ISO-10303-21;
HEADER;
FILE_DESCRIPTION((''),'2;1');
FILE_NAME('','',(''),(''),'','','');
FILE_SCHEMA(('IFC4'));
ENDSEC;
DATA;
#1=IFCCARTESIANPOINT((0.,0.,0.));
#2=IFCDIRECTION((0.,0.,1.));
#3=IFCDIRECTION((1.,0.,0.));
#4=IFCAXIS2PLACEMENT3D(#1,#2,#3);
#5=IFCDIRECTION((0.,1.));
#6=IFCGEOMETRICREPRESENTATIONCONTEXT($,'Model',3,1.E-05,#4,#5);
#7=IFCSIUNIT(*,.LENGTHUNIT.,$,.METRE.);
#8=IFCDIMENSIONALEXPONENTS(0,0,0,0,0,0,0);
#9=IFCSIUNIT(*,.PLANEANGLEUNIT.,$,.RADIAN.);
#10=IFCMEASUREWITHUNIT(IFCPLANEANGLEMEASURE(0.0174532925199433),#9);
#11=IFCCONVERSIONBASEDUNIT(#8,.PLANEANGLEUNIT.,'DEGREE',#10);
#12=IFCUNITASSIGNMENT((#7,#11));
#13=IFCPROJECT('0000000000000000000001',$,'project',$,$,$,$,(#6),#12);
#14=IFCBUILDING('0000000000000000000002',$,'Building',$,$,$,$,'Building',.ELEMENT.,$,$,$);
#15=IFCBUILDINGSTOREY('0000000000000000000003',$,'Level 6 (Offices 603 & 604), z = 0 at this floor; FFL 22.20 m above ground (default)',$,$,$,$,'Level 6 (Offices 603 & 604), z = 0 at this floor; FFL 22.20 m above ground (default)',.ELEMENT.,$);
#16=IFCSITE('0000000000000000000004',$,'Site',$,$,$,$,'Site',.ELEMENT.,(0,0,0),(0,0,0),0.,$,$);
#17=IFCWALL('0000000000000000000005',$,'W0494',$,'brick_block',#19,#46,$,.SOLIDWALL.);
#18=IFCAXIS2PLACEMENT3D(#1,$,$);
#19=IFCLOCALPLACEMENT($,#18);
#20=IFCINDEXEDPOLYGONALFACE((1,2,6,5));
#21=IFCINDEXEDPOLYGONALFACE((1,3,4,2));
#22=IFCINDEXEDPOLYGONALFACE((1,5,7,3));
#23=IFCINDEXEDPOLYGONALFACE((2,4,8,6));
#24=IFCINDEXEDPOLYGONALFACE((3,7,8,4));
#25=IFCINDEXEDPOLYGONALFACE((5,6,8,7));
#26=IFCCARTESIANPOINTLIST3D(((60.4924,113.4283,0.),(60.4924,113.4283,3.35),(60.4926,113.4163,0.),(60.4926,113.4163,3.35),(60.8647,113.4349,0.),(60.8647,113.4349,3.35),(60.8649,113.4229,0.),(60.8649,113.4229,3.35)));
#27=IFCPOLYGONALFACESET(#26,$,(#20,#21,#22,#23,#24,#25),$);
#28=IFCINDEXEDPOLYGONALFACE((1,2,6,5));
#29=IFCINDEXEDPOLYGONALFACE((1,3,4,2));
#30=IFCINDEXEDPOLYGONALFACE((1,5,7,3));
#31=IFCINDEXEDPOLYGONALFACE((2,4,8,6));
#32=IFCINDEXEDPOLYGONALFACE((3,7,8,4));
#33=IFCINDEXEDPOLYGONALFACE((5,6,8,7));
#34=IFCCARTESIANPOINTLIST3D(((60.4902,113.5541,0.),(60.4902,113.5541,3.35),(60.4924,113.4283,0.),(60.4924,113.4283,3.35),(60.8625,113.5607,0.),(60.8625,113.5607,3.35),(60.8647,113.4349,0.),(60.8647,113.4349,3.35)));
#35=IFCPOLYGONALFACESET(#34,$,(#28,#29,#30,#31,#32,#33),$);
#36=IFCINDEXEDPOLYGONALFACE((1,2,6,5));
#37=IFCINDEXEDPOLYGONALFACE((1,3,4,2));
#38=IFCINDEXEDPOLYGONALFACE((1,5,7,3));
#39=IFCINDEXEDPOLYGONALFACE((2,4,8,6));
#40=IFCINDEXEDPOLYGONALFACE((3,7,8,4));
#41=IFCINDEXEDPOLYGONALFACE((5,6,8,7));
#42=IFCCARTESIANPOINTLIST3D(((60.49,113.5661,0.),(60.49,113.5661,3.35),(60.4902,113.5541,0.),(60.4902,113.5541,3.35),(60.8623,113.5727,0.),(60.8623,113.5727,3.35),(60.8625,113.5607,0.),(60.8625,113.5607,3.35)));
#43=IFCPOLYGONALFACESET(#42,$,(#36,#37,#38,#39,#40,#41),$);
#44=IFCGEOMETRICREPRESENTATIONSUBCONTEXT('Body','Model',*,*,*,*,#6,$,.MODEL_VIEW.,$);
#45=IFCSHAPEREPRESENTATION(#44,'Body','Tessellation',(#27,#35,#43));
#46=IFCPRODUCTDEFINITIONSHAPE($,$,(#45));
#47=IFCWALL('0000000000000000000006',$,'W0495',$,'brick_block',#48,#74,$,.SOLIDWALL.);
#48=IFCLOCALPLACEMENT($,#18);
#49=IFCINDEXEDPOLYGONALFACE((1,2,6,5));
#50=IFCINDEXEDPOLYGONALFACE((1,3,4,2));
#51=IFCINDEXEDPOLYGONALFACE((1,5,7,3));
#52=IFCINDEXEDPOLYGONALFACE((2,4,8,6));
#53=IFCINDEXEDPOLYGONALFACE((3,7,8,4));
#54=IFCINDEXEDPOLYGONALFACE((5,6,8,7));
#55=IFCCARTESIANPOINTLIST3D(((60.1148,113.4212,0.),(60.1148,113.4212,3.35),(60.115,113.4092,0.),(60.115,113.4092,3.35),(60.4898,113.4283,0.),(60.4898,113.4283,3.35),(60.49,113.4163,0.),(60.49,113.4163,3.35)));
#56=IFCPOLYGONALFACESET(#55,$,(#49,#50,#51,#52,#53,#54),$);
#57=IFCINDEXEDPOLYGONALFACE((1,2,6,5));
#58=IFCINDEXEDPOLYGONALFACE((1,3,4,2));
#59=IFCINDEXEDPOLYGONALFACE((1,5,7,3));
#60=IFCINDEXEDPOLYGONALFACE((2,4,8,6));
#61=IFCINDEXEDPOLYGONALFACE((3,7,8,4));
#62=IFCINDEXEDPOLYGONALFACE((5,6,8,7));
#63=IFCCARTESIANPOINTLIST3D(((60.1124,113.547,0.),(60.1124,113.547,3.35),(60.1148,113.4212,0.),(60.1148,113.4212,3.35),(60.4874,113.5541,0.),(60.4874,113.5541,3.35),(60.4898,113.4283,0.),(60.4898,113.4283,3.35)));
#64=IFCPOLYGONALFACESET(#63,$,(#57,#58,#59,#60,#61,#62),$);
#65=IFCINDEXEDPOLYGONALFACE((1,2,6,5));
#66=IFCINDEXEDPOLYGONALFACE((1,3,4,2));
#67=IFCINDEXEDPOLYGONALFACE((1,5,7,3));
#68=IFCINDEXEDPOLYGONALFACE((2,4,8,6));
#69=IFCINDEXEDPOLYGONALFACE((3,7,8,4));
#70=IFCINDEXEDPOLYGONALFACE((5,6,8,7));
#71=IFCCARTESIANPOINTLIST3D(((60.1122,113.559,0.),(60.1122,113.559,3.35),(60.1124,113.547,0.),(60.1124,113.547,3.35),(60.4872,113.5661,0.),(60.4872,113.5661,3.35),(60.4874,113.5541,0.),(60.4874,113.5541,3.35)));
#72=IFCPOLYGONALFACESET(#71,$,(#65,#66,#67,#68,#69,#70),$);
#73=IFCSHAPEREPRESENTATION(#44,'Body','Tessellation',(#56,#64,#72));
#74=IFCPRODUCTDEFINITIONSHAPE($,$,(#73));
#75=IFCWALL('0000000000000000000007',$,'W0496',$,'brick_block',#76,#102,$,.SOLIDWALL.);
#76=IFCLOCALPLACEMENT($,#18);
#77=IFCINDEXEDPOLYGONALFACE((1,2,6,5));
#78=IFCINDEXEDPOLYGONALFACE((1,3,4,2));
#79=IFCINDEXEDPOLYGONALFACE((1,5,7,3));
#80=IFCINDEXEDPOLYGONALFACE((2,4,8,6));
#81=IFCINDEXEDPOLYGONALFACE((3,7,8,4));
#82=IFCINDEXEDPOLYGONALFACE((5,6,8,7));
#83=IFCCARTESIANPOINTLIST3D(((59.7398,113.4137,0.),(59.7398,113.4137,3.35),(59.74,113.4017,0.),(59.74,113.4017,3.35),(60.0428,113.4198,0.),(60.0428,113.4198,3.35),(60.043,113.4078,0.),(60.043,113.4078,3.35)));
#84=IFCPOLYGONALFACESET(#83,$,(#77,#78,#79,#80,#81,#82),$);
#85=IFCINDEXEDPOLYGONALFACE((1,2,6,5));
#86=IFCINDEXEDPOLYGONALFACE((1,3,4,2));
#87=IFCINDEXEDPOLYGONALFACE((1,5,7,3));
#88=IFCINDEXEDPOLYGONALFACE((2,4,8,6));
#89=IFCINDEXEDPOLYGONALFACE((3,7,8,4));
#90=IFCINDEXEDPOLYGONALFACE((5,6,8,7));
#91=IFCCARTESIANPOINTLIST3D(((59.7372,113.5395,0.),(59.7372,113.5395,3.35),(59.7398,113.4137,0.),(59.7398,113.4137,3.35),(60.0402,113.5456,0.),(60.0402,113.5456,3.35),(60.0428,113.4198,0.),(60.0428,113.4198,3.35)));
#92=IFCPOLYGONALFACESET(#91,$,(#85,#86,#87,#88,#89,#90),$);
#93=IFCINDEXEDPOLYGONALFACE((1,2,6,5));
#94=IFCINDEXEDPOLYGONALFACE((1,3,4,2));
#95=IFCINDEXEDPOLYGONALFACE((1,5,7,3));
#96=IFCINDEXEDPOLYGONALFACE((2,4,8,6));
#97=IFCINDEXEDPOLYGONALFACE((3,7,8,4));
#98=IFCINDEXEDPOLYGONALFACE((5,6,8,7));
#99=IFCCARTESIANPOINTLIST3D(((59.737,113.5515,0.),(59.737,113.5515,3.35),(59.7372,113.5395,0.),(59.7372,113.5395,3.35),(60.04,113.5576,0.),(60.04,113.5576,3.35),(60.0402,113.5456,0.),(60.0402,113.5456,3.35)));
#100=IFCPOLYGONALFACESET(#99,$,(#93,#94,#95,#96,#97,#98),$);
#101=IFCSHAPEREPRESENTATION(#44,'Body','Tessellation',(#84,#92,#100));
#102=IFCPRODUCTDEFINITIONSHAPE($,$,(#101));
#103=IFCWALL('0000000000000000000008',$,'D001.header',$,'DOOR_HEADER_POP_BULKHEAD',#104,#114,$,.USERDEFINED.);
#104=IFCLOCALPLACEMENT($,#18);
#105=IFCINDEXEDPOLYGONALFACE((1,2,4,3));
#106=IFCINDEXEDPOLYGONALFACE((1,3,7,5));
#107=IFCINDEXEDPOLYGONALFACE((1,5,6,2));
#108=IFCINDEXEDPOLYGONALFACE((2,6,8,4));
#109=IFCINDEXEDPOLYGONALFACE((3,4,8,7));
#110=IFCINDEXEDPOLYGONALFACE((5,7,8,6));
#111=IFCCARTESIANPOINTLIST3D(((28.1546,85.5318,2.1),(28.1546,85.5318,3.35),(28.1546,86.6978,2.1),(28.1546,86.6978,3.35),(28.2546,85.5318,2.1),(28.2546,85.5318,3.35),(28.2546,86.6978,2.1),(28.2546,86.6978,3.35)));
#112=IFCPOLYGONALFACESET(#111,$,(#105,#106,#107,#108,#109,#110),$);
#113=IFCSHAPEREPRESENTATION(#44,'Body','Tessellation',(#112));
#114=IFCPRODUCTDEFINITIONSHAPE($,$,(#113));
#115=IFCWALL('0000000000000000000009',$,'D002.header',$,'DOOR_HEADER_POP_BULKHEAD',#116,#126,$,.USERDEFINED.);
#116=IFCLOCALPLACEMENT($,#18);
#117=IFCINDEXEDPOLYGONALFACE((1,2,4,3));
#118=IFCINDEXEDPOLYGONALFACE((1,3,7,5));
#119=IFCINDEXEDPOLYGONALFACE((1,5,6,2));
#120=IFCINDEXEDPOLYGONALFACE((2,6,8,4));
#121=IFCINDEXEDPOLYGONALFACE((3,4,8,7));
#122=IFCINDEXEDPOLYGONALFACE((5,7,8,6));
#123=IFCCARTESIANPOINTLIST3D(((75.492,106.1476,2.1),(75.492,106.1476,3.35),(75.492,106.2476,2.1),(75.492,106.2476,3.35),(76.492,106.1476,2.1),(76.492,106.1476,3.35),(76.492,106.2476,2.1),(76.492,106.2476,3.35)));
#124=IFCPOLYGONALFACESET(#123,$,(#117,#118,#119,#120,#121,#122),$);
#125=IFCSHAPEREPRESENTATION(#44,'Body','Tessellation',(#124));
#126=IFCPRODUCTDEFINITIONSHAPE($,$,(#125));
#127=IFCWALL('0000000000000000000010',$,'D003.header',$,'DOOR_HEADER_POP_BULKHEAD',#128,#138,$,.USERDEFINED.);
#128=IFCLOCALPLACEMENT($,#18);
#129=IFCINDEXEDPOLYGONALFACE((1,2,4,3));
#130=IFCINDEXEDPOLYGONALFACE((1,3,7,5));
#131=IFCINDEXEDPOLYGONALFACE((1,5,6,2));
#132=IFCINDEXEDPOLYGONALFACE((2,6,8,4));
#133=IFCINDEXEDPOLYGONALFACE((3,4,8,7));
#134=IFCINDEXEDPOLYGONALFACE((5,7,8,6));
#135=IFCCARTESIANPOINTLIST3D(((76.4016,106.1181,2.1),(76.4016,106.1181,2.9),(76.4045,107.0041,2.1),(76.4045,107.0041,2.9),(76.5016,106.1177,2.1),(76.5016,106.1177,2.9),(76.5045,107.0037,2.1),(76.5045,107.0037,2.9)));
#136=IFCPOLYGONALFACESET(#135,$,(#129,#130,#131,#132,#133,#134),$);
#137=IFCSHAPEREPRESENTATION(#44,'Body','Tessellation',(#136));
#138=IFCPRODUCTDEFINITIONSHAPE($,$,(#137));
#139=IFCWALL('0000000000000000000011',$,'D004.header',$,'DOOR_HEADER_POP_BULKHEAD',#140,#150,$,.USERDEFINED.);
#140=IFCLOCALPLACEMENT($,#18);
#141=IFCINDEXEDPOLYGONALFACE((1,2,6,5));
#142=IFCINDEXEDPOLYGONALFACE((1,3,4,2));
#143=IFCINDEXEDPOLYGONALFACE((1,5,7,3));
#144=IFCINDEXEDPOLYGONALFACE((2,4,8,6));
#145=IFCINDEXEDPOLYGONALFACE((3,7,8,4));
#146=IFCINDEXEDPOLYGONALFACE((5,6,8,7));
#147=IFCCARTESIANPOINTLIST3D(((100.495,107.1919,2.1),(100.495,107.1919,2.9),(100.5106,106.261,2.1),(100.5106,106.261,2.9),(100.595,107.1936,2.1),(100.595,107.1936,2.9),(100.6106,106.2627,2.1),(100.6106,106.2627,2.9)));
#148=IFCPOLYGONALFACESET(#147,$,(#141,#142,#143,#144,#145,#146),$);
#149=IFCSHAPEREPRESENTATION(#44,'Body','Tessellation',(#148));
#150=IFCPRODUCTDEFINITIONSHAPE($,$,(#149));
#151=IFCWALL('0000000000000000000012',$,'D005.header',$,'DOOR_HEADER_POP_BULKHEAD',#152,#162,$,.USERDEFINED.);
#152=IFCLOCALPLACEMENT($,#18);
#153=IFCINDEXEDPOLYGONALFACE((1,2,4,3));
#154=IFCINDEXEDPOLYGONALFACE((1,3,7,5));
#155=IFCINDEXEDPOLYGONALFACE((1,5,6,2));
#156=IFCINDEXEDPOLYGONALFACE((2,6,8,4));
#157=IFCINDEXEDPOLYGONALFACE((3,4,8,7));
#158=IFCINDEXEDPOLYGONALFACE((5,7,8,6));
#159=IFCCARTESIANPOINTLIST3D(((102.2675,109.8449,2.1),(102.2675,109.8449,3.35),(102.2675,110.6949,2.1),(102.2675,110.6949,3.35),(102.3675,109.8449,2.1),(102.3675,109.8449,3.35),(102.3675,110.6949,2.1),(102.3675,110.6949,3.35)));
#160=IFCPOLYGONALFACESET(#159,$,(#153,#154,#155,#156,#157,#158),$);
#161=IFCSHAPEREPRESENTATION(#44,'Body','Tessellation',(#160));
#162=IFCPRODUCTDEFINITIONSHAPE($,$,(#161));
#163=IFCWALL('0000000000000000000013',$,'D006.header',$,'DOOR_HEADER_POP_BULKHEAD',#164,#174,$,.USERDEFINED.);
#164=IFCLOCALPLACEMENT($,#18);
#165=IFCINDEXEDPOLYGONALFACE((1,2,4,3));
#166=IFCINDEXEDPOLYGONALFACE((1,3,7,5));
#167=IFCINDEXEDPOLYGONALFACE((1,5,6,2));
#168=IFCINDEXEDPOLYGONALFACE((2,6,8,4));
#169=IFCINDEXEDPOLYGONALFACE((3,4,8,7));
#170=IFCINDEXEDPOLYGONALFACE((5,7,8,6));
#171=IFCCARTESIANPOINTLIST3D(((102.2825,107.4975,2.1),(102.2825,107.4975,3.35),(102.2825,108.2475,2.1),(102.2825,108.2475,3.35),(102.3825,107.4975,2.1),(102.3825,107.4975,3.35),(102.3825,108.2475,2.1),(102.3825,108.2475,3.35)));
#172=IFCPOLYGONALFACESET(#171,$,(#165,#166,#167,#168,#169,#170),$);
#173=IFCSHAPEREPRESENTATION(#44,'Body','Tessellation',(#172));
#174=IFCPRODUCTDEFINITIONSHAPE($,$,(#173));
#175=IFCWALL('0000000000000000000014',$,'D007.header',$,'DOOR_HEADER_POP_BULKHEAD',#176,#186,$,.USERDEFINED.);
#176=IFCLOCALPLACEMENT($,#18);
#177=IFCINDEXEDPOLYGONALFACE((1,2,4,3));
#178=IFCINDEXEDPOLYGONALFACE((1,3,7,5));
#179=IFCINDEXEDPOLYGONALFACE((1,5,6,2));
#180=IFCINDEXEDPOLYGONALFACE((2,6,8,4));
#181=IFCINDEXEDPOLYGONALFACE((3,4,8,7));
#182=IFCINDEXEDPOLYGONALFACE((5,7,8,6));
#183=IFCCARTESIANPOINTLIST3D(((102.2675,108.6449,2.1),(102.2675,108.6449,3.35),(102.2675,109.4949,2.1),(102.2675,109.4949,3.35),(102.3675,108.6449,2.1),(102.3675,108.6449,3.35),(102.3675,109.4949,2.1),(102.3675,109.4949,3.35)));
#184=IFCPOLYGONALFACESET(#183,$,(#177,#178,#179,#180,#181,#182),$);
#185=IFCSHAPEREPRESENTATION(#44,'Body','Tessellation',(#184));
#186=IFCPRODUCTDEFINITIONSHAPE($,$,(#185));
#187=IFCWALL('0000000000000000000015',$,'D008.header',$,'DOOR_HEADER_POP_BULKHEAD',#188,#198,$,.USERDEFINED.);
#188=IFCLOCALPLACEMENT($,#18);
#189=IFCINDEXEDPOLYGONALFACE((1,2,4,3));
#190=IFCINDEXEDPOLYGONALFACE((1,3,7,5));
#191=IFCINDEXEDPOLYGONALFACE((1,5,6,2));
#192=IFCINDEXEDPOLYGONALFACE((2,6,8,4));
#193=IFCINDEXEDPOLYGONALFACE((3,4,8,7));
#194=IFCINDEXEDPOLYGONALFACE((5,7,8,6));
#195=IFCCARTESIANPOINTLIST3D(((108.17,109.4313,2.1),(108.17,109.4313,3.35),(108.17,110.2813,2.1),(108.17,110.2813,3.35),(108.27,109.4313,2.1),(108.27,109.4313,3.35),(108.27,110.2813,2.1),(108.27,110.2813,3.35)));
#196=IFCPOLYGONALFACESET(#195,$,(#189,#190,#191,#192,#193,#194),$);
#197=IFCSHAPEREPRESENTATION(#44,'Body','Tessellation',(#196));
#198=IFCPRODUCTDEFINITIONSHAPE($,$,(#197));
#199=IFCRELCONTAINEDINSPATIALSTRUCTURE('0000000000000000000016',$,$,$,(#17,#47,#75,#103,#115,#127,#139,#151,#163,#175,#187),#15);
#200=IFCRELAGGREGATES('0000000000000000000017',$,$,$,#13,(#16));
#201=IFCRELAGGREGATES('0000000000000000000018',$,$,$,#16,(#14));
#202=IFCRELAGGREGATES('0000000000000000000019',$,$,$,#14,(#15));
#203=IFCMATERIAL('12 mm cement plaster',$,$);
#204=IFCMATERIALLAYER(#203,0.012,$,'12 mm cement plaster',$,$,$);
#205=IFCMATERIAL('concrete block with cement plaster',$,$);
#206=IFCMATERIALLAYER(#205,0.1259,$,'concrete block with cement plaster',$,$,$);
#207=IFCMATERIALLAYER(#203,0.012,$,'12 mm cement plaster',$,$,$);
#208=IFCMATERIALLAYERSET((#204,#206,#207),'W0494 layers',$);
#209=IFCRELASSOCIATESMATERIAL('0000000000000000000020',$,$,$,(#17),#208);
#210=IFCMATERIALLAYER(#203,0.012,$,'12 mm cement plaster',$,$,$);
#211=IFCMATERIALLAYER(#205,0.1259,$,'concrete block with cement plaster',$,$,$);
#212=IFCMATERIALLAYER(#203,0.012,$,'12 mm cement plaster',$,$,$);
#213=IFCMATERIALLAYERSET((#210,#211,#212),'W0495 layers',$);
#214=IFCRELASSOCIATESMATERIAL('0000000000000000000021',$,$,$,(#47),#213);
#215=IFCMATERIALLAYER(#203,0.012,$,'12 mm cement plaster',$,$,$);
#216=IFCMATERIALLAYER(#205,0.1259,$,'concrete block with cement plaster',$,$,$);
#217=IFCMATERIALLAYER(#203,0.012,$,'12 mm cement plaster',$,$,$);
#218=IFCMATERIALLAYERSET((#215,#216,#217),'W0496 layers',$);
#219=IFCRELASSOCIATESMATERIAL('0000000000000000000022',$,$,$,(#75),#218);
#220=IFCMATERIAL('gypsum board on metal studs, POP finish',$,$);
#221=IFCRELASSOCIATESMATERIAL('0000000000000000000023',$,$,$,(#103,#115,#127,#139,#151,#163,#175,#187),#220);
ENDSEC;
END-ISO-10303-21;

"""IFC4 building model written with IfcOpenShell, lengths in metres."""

from ifc_helpers import new_model, entity, si_unit, converted_unit, direction, frame, frame_2d, origin_with_axes, origin_2d_with_axis, place, context, subcontext, project, spatial, rectangle, extrude, material, layer, layer_set, layer_usage, element, save


model = new_model("IFC4")

# Units and contexts
model_context = context("Model", 3, precision=1e-05, world=origin_with_axes(), true_north=direction((0.0, 1.0)))
body_context = subcontext(model_context, "Body", "Model", "MODEL_VIEW")
ifc_project = project(units=[si_unit("LENGTHUNIT", "METRE"), converted_unit("PLANEANGLEUNIT", "DEGREE", entity("IfcPlaneAngleMeasure", 0.0174532925199433), si_unit("PLANEANGLEUNIT", "RADIAN"), dimensions=[0, 0, 0, 0, 0, 0, 0])], contexts=[model_context])

# Site, building, storey
site = spatial("IfcSite", under=ifc_project, Name="Site", LongName="Site", CompositionType="ELEMENT", RefLatitude=(0, 0, 0), RefLongitude=(0, 0, 0), RefElevation=0.0)
building = spatial("IfcBuilding", under=site, Name="Building", LongName="Building", CompositionType="ELEMENT")
storey = spatial("IfcBuildingStorey", under=building, Name="Level 6 (Offices 603 & 604), z = 0 at this floor; FFL 22.20 m above ground (default)", LongName="Level 6 (Offices 603 & 604), z = 0 at this floor; FFL 22.20 m above ground (default)", CompositionType="ELEMENT")

# Shared definitions
placement = place(None, origin_with_axes())

# Walls
ifc_material_1 = material(Name="12 mm cement plaster")
ifc_material_2 = material(Name="concrete block with cement plaster")
ifc_layer_1 = layer(ifc_material_1, 0.012, Name="12 mm cement plaster")
ifc_layer_2 = layer(ifc_material_2, 0.1259, Name="concrete block with cement plaster")
ifc_layer_3 = layer(ifc_material_1, 0.012, Name="12 mm cement plaster")
ifc_layer_set_1 = layer_set([ifc_layer_1, ifc_layer_2, ifc_layer_3], Name="W0494 layers")
ifc_layer_usage_1 = layer_usage(ifc_layer_set_1, "AXIS2", "POSITIVE", -0.075)
element("IfcWall", 1, at=placement, inside=storey, material=ifc_layer_usage_1, Name="W0494", ObjectType="brick_block", PredefinedType="SOLIDWALL", context=body_context, shape_type="SweptSolid", body=[
    extrude(rectangle(XDim=0.3724, YDim=0.012, at=frame_2d((0.0, 0.0), x_axis=(0.999843, 0.017725))), frame((60.6787, 113.4256, 0.0), z_axis=(0.0, 0.0, 1.0), x_axis=(1.0, 0.0, 0.0)), (0.0, 0.0, 1.0), 3.35),
    extrude(rectangle(XDim=0.3724, YDim=0.1259, at=frame_2d((-0.0012, 0.0689), x_axis=(0.999843, 0.017725))), frame((60.6787, 113.4256, 0.0), z_axis=(0.0, 0.0, 1.0), x_axis=(1.0, 0.0, 0.0)), (0.0, 0.0, 1.0), 3.35),
    extrude(rectangle(XDim=0.3724, YDim=0.012, at=frame_2d((-0.0024, 0.1379), x_axis=(0.999843, 0.017725))), frame((60.6787, 113.4256, 0.0), z_axis=(0.0, 0.0, 1.0), x_axis=(1.0, 0.0, 0.0)), (0.0, 0.0, 1.0), 3.35),
])
ifc_layer_4 = layer(ifc_material_1, 0.012, Name="12 mm cement plaster")
ifc_layer_5 = layer(ifc_material_2, 0.1259, Name="concrete block with cement plaster")
ifc_layer_6 = layer(ifc_material_1, 0.012, Name="12 mm cement plaster")
ifc_layer_set_2 = layer_set([ifc_layer_4, ifc_layer_5, ifc_layer_6], Name="W0495 layers")
ifc_layer_usage_2 = layer_usage(ifc_layer_set_2, "AXIS2", "POSITIVE", -0.075)
element("IfcWall", 2, at=placement, inside=storey, material=ifc_layer_usage_2, Name="W0495", ObjectType="brick_block", PredefinedType="SOLIDWALL", context=body_context, shape_type="SweptSolid", body=[
    extrude(rectangle(XDim=0.3751, YDim=0.012, at=frame_2d((0.0, 0.0), x_axis=(0.999821, 0.01893))), frame((60.3024, 113.4187, 0.0), z_axis=(0.0, 0.0, 1.0), x_axis=(1.0, 0.0, 0.0)), (0.0, 0.0, 1.0), 3.35),
    extrude(rectangle(XDim=0.3751, YDim=0.1259, at=frame_2d((-0.0013, 0.0689), x_axis=(0.999821, 0.01893))), frame((60.3024, 113.4187, 0.0), z_axis=(0.0, 0.0, 1.0), x_axis=(1.0, 0.0, 0.0)), (0.0, 0.0, 1.0), 3.35),
    extrude(rectangle(XDim=0.3751, YDim=0.012, at=frame_2d((-0.0026, 0.1379), x_axis=(0.999821, 0.01893))), frame((60.3024, 113.4187, 0.0), z_axis=(0.0, 0.0, 1.0), x_axis=(1.0, 0.0, 0.0)), (0.0, 0.0, 1.0), 3.35),
])
ifc_layer_7 = layer(ifc_material_1, 0.012, Name="12 mm cement plaster")
ifc_layer_8 = layer(ifc_material_2, 0.1259, Name="concrete block with cement plaster")
ifc_layer_9 = layer(ifc_material_1, 0.012, Name="12 mm cement plaster")
ifc_layer_set_3 = layer_set([ifc_layer_7, ifc_layer_8, ifc_layer_9], Name="W0496 layers")
ifc_layer_usage_3 = layer_usage(ifc_layer_set_3, "AXIS2", "POSITIVE", -0.075)
element("IfcWall", 3, at=placement, inside=storey, material=ifc_layer_usage_3, Name="W0496", ObjectType="brick_block", PredefinedType="SOLIDWALL", context=body_context, shape_type="SweptSolid", body=[
    extrude(rectangle(XDim=0.3031, YDim=0.012, at=frame_2d((0.0, 0.0), x_axis=(0.999797, 0.020128))), frame((59.8914, 113.4107, 0.0), z_axis=(0.0, 0.0, 1.0), x_axis=(1.0, 0.0, 0.0)), (0.0, 0.0, 1.0), 3.35),
    extrude(rectangle(XDim=0.3031, YDim=0.1259, at=frame_2d((-0.0014, 0.0689), x_axis=(0.999797, 0.020128))), frame((59.8914, 113.4107, 0.0), z_axis=(0.0, 0.0, 1.0), x_axis=(1.0, 0.0, 0.0)), (0.0, 0.0, 1.0), 3.35),
    extrude(rectangle(XDim=0.3031, YDim=0.012, at=frame_2d((-0.0028, 0.1379), x_axis=(0.999797, 0.020128))), frame((59.8914, 113.4107, 0.0), z_axis=(0.0, 0.0, 1.0), x_axis=(1.0, 0.0, 0.0)), (0.0, 0.0, 1.0), 3.35),
])
ifc_material_3 = material(Name="gypsum board on metal studs, POP finish")
element("IfcWall", 4, at=placement, inside=storey, material=ifc_material_3, Name="D001.header", ObjectType="DOOR_HEADER_POP_BULKHEAD", PredefinedType="USERDEFINED", context=body_context, shape_type="SweptSolid", body=[
    extrude(rectangle(XDim=1.166, YDim=0.1, at=frame_2d((0.0, 0.0), x_axis=(0.0, 1.0))), frame((28.2046, 86.1148, 2.1), z_axis=(0.0, 0.0, 1.0), x_axis=(1.0, 0.0, 0.0)), (0.0, 0.0, 1.0), 1.25),
])
element("IfcWall", 5, at=placement, inside=storey, material=ifc_material_3, Name="D002.header", ObjectType="DOOR_HEADER_POP_BULKHEAD", PredefinedType="USERDEFINED", context=body_context, shape_type="SweptSolid", body=[
    extrude(rectangle(XDim=1.0, YDim=0.1, at=origin_2d_with_axis()), frame((75.992, 106.1976, 2.1), z_axis=(0.0, 0.0, 1.0), x_axis=(1.0, 0.0, 0.0)), (0.0, 0.0, 1.0), 1.25),
])
element("IfcWall", 6, at=placement, inside=storey, material=ifc_material_3, Name="D003.header", ObjectType="DOOR_HEADER_POP_BULKHEAD", PredefinedType="USERDEFINED", context=body_context, shape_type="SweptSolid", body=[
    extrude(rectangle(XDim=0.886, YDim=0.1, at=frame_2d((0.0, 0.0), x_axis=(0.003275, 0.999995))), frame((76.4531, 106.5609, 2.1), z_axis=(0.0, 0.0, 1.0), x_axis=(1.0, 0.0, 0.0)), (0.0, 0.0, 1.0), 0.8),
])
element("IfcWall", 7, at=placement, inside=storey, material=ifc_material_3, Name="D004.header", ObjectType="DOOR_HEADER_POP_BULKHEAD", PredefinedType="USERDEFINED", context=body_context, shape_type="SweptSolid", body=[
    extrude(rectangle(XDim=0.931, YDim=0.1, at=frame_2d((0.0, 0.0), x_axis=(0.016765, -0.999859))), frame((100.5528, 106.7273, 2.1), z_axis=(0.0, 0.0, 1.0), x_axis=(1.0, 0.0, 0.0)), (0.0, 0.0, 1.0), 0.8),
])
element("IfcWall", 8, at=placement, inside=storey, material=ifc_material_3, Name="D005.header", ObjectType="DOOR_HEADER_POP_BULKHEAD", PredefinedType="USERDEFINED", context=body_context, shape_type="SweptSolid", body=[
    extrude(rectangle(XDim=0.85, YDim=0.1, at=frame_2d((0.0, 0.0), x_axis=(0.0, 1.0))), frame((102.3175, 110.2699, 2.1), z_axis=(0.0, 0.0, 1.0), x_axis=(1.0, 0.0, 0.0)), (0.0, 0.0, 1.0), 1.25),
])
element("IfcWall", 9, at=placement, inside=storey, material=ifc_material_3, Name="D006.header", ObjectType="DOOR_HEADER_POP_BULKHEAD", PredefinedType="USERDEFINED", context=body_context, shape_type="SweptSolid", body=[
    extrude(rectangle(XDim=0.75, YDim=0.1, at=frame_2d((0.0, 0.0), x_axis=(0.0, 1.0))), frame((102.3325, 107.8725, 2.1), z_axis=(0.0, 0.0, 1.0), x_axis=(1.0, 0.0, 0.0)), (0.0, 0.0, 1.0), 1.25),
])
element("IfcWall", 10, at=placement, inside=storey, material=ifc_material_3, Name="D007.header", ObjectType="DOOR_HEADER_POP_BULKHEAD", PredefinedType="USERDEFINED", context=body_context, shape_type="SweptSolid", body=[
    extrude(rectangle(XDim=0.85, YDim=0.1, at=frame_2d((0.0, 0.0), x_axis=(0.0, 1.0))), frame((102.3175, 109.0699, 2.1), z_axis=(0.0, 0.0, 1.0), x_axis=(1.0, 0.0, 0.0)), (0.0, 0.0, 1.0), 1.25),
])
element("IfcWall", 11, at=placement, inside=storey, material=ifc_material_3, Name="D008.header", ObjectType="DOOR_HEADER_POP_BULKHEAD", PredefinedType="USERDEFINED", context=body_context, shape_type="SweptSolid", body=[
    extrude(rectangle(XDim=0.85, YDim=0.1, at=frame_2d((0.0, 0.0), x_axis=(0.0, 1.0))), frame((108.22, 109.8563, 2.1), z_axis=(0.0, 0.0, 1.0), x_axis=(1.0, 0.0, 0.0)), (0.0, 0.0, 1.0), 1.25),
])

save(model, "model.ifc")
